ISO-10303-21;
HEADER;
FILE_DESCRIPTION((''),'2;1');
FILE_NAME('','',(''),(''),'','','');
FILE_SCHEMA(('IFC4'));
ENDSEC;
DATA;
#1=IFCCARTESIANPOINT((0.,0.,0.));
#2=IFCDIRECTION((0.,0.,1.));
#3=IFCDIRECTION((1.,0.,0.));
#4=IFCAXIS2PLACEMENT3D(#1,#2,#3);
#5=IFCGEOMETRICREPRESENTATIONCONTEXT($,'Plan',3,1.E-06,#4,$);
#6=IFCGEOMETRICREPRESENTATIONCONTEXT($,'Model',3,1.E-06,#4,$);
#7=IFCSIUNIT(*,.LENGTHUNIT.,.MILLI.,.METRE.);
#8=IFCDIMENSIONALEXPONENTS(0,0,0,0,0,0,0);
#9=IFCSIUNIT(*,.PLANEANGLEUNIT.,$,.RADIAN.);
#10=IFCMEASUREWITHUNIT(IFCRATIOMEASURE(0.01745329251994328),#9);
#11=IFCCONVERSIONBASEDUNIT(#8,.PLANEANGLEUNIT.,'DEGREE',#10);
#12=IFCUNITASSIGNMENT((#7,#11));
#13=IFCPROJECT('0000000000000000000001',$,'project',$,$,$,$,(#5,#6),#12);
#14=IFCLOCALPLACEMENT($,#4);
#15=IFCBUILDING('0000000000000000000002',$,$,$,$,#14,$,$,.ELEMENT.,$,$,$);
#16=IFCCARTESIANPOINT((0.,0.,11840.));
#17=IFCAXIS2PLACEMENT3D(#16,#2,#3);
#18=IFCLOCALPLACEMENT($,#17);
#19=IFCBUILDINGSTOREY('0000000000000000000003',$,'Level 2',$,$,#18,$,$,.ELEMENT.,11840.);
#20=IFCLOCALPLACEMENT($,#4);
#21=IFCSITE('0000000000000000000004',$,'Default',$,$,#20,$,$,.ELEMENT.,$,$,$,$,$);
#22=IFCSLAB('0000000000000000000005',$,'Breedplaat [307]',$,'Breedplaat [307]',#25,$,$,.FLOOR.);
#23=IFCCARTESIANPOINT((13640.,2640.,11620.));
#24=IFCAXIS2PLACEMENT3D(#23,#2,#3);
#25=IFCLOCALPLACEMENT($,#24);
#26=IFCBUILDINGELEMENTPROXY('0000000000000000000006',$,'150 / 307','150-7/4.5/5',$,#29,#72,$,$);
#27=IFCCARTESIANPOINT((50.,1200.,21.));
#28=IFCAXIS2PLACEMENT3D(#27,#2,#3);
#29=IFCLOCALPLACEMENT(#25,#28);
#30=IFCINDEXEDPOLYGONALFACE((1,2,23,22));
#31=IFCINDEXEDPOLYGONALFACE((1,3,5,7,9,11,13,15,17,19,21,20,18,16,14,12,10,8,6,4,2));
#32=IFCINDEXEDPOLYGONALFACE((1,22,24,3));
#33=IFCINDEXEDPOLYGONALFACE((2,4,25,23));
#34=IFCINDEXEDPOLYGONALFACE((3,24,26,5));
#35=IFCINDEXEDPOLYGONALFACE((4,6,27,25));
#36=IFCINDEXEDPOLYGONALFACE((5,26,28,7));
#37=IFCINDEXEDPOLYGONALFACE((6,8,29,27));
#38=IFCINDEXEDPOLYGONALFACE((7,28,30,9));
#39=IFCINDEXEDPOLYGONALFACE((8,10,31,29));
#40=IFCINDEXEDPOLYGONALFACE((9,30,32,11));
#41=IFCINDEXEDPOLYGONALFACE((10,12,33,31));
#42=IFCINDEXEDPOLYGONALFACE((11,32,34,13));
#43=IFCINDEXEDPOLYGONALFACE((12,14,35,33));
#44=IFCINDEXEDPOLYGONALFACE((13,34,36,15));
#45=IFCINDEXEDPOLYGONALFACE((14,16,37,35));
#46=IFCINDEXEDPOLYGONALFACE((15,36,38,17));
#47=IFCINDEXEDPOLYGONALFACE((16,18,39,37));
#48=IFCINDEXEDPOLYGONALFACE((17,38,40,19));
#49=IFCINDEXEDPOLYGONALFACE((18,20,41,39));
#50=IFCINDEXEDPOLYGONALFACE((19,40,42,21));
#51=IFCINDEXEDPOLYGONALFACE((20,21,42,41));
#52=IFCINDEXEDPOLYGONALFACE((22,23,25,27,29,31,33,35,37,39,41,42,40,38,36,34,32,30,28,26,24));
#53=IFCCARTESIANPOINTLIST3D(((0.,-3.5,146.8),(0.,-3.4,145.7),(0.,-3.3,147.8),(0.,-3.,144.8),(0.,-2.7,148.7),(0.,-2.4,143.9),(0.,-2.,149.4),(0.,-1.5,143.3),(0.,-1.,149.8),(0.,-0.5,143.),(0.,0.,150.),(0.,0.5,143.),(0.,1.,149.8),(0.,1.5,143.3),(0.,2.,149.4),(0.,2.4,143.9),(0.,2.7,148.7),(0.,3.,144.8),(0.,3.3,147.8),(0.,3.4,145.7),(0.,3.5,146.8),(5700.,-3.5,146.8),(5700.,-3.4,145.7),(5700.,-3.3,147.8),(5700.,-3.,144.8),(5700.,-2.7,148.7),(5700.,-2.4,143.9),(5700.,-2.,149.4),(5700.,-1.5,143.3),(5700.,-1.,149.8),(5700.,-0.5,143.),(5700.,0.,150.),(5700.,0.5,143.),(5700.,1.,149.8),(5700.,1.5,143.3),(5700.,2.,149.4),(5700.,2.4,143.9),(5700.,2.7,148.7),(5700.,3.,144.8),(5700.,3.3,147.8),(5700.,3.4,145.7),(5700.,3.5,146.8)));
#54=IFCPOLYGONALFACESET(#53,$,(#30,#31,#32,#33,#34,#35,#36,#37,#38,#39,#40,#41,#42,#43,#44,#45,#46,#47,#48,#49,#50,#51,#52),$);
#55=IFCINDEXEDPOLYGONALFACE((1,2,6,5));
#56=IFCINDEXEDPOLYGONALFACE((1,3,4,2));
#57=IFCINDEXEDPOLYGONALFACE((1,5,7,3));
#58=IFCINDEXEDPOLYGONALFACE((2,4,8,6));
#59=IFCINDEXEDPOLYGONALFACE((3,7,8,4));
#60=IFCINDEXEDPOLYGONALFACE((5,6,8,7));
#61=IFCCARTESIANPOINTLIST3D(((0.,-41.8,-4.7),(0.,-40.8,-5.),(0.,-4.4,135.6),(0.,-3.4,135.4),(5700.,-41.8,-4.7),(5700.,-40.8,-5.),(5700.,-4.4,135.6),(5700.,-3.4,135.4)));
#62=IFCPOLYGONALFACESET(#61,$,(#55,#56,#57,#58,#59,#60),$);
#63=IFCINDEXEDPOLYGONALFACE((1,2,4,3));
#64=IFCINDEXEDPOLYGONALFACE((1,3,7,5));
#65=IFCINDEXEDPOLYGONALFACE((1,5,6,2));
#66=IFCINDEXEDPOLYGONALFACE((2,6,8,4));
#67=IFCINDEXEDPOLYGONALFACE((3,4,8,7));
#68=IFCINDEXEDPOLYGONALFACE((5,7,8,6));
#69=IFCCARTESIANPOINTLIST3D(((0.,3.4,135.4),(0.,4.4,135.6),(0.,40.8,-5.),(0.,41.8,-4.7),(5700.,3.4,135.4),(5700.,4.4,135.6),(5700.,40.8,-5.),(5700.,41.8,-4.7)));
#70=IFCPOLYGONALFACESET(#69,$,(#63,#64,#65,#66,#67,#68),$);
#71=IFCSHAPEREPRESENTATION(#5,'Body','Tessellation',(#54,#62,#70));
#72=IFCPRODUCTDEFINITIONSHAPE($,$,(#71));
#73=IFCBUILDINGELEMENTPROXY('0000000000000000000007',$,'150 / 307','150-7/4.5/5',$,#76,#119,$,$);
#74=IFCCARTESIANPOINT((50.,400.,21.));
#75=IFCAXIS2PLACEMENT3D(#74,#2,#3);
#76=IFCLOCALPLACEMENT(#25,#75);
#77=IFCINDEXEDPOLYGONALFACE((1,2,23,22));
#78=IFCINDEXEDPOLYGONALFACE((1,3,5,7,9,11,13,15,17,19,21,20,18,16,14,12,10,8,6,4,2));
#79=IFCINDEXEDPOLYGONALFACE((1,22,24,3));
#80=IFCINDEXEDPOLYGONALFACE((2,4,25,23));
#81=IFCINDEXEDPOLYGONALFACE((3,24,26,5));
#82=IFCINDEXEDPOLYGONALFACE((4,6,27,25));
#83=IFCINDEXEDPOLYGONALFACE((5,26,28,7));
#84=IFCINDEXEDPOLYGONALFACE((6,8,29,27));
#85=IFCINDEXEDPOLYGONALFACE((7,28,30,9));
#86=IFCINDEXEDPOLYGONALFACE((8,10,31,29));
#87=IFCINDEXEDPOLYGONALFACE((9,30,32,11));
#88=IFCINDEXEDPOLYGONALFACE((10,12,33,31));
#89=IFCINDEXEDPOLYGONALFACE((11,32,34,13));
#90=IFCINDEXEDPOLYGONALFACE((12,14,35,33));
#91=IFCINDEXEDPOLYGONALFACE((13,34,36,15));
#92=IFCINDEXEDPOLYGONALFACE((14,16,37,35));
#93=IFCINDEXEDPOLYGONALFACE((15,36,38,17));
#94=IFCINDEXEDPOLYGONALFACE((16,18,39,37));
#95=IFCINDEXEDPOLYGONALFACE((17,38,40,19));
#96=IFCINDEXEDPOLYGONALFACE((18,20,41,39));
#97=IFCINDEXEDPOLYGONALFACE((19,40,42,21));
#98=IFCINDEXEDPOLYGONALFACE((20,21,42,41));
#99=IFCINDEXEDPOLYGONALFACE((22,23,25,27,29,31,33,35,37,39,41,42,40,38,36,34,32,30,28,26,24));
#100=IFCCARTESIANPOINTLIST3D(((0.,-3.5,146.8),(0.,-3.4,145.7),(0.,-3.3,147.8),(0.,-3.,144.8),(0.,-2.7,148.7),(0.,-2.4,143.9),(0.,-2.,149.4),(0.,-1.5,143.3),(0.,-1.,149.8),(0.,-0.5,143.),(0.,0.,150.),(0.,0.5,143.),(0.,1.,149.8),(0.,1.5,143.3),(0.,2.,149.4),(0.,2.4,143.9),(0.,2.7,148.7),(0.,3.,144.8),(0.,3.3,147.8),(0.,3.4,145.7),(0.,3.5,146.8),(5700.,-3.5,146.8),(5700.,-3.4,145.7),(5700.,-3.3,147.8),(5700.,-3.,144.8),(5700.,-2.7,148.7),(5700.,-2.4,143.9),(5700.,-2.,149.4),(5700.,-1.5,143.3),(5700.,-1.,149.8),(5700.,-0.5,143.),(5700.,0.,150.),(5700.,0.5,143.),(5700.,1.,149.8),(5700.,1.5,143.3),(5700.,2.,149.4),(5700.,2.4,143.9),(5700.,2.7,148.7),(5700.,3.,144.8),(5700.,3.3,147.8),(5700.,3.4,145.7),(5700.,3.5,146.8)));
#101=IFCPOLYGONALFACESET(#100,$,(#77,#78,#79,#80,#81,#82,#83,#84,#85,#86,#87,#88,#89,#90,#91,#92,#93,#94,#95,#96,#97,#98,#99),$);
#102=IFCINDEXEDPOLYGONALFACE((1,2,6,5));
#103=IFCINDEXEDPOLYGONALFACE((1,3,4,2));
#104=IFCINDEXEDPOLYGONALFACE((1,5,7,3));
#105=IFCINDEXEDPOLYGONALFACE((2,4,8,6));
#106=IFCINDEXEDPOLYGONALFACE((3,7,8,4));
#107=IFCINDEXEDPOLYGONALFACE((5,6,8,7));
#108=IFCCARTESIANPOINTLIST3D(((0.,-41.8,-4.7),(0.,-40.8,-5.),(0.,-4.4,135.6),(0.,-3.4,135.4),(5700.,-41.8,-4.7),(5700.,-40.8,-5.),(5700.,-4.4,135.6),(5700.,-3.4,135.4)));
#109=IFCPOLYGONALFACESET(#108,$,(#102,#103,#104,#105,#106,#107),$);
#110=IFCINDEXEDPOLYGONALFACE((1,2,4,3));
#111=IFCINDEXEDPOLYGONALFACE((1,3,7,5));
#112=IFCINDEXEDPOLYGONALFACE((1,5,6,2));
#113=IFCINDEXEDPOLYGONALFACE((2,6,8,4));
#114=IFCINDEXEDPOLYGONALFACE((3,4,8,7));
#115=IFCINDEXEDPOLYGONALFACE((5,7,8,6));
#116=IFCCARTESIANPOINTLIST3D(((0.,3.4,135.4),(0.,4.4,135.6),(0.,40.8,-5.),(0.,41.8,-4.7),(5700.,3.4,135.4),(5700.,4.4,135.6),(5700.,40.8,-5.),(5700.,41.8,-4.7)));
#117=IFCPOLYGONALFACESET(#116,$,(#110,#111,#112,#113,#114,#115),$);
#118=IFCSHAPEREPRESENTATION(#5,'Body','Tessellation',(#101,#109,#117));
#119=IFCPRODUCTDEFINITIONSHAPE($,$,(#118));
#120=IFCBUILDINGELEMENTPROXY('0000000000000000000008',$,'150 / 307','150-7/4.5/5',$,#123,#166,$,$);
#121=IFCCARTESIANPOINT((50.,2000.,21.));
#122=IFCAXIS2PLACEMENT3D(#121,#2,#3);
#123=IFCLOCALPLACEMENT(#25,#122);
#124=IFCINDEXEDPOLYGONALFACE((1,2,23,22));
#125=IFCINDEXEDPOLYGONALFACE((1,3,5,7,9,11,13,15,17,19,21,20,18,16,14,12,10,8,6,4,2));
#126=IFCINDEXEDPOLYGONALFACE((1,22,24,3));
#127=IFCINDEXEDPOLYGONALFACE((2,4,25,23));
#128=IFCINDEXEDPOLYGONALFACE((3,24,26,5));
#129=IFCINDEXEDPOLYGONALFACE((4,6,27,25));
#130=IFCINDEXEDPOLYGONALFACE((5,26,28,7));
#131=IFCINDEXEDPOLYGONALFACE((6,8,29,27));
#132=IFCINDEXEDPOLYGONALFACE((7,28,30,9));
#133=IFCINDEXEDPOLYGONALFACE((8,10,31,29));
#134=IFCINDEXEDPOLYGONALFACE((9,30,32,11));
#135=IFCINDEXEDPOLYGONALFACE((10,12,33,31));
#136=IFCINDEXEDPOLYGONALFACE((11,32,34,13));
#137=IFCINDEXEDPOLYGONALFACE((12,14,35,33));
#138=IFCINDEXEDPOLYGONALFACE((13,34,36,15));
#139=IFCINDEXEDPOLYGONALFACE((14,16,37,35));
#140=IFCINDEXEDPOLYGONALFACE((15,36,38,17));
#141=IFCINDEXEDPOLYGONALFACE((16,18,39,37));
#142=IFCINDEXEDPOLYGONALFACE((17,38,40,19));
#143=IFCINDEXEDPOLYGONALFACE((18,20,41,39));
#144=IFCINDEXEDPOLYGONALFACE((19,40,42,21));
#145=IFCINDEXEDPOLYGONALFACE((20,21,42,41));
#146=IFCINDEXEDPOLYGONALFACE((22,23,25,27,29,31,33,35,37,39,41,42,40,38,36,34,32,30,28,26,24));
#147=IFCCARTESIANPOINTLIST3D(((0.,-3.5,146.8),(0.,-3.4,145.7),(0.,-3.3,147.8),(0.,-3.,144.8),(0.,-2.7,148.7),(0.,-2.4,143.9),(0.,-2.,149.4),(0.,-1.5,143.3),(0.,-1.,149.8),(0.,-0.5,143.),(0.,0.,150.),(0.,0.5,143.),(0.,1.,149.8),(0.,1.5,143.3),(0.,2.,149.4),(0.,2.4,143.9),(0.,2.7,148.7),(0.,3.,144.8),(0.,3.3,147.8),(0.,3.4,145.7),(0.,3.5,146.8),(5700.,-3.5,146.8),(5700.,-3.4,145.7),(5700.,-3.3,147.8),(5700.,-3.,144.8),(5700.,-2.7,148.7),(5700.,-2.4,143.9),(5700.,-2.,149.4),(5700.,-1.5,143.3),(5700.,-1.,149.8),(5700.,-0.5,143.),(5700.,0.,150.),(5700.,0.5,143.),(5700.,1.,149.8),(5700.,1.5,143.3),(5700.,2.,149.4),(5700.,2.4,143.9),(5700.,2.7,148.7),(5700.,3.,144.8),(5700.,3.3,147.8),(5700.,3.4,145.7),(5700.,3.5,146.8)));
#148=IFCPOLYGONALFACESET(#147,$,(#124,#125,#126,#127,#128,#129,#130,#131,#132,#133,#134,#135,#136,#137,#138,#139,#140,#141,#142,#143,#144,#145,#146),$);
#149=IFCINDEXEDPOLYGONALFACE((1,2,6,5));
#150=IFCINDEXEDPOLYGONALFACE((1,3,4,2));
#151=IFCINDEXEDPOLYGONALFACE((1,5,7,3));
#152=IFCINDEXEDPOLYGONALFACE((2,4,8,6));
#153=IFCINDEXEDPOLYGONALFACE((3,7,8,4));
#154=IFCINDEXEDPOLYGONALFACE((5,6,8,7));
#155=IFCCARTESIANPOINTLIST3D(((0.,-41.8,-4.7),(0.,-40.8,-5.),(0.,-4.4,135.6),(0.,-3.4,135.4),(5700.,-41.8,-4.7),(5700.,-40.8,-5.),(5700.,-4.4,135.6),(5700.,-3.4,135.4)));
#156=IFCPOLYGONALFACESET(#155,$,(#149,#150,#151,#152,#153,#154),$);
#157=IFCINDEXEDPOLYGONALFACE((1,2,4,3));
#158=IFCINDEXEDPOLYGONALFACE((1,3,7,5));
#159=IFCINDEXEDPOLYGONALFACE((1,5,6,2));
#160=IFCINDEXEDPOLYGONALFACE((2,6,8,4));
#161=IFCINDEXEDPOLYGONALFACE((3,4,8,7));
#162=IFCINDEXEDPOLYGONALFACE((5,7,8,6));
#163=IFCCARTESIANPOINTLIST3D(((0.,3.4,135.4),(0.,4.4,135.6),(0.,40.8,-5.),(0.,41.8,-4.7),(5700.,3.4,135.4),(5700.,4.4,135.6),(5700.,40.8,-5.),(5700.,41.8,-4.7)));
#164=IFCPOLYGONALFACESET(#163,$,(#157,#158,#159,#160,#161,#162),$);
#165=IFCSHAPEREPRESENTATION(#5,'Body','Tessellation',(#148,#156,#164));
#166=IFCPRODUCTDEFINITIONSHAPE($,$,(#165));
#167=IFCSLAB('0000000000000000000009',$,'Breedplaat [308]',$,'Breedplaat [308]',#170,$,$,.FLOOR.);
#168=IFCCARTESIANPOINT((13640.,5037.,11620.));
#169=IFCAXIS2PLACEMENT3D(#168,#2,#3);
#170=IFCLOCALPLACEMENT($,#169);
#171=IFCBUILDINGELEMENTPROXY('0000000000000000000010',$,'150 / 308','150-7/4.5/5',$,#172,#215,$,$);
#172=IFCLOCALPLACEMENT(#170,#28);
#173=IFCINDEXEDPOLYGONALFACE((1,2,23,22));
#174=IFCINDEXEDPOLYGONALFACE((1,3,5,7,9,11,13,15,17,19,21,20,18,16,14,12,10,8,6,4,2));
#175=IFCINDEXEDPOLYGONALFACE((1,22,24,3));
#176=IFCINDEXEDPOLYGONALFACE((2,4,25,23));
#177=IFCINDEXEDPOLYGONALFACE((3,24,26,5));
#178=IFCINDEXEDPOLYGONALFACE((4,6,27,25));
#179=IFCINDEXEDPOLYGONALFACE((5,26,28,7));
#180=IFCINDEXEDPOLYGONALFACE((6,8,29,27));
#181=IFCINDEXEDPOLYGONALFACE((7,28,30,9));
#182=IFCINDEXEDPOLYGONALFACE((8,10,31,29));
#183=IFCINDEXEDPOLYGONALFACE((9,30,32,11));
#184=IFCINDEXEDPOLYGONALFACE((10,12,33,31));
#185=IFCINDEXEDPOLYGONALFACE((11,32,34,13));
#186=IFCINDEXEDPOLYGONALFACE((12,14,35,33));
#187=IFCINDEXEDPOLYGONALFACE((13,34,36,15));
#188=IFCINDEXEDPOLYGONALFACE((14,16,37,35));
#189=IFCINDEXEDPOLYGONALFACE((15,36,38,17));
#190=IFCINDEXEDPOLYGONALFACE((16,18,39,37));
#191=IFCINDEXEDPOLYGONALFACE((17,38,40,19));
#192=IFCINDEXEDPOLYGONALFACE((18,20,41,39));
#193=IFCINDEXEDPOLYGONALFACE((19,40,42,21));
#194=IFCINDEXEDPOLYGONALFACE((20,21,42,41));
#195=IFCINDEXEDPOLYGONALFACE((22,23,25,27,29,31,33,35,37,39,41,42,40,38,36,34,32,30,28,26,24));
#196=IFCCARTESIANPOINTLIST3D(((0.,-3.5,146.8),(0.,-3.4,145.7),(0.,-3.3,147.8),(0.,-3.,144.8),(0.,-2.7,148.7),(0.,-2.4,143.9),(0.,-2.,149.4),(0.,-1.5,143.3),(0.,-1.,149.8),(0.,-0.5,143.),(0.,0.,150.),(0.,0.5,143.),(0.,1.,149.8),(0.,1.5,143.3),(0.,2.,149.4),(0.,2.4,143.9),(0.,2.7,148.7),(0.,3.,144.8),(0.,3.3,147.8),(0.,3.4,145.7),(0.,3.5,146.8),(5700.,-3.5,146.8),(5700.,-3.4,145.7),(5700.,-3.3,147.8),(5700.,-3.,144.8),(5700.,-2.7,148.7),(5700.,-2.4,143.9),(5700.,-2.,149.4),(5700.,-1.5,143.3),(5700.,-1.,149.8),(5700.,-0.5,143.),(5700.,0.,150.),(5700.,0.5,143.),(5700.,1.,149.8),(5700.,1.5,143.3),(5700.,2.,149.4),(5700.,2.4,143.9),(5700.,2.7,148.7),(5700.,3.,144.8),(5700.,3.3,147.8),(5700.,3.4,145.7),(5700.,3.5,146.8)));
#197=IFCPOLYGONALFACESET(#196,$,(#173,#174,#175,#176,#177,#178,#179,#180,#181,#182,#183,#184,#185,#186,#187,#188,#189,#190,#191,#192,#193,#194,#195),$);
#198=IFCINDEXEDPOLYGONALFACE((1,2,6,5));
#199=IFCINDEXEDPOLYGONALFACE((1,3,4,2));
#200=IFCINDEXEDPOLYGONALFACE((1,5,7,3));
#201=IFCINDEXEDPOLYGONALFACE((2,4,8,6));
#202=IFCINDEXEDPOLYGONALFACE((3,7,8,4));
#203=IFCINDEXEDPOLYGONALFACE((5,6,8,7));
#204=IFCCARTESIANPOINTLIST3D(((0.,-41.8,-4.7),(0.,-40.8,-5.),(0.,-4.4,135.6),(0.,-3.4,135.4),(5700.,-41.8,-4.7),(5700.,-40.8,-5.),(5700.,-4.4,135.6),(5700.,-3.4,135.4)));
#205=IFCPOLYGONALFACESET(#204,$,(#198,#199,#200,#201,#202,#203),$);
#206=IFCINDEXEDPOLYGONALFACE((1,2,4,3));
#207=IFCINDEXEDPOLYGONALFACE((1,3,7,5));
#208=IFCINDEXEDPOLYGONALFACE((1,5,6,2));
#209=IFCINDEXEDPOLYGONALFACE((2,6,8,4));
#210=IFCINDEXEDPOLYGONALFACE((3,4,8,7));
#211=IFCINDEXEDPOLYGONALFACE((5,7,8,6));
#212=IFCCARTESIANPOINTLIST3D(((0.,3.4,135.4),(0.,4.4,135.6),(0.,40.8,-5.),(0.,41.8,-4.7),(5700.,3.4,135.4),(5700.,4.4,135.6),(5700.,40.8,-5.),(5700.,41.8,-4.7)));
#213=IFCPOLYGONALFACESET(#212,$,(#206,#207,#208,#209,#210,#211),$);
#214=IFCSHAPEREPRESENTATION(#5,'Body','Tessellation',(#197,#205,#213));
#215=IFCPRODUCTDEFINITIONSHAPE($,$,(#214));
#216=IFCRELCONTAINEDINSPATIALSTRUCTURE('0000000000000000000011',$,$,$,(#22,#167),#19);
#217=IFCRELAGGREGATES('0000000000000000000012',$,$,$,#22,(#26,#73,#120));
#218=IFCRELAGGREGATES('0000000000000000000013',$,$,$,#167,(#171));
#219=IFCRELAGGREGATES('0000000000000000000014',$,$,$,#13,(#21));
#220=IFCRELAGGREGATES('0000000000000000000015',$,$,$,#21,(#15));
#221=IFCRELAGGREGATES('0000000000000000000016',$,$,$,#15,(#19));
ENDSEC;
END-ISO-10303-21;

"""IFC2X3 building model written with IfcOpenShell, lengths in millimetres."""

from ifc_helpers import new_model, entity, si_unit, converted_unit, frame, origin_with_axes, origin_2d_with_axis, place, context, project, spatial, rectangle, circle, extrude, element, aggregate, save


model = new_model("IFC2X3")

# Units and contexts
plan_context = context("Plan", 3, precision=1e-06, world=origin_with_axes())
model_context = context("Model", 3, precision=1e-06, world=origin_with_axes())
ifc_project = project(units=[si_unit("LENGTHUNIT", "METRE", prefix="MILLI"), converted_unit("PLANEANGLEUNIT", "DEGREE", entity("IfcRatioMeasure", 0.01745329251994328), si_unit("PLANEANGLEUNIT", "RADIAN"), dimensions=[0, 0, 0, 0, 0, 0, 0])], contexts=[plan_context, model_context])

# Site, building, storey
site_placement = place(None, origin_with_axes())
site = spatial("IfcSite", under=ifc_project, at=site_placement, Name="Default", CompositionType="ELEMENT")
building_placement = place(None, origin_with_axes())
building = spatial("IfcBuilding", under=site, at=building_placement, CompositionType="ELEMENT")
storey_placement = place(None, frame((0.0, 0.0, 11840.0), z_axis=(0.0, 0.0, 1.0), x_axis=(1.0, 0.0, 0.0)))
storey = spatial("IfcBuildingStorey", under=building, at=storey_placement, Name="Level 2", CompositionType="ELEMENT", Elevation=11840.0)

# Slabs, building element proxies
slab_1_placement = place(None, frame((13640.0, 2640.0, 11620.0), z_axis=(0.0, 0.0, 1.0), x_axis=(1.0, 0.0, 0.0)))
slab_1 = element("IfcSlab", 1, at=slab_1_placement, inside=storey, Name="Breedplaat [307]", ObjectType="Breedplaat [307]", PredefinedType="FLOOR")
proxy_1_placement = place(slab_1_placement, frame((50.0, 1200.0, 21.0), z_axis=(0.0, 0.0, 1.0), x_axis=(1.0, 0.0, 0.0)))
proxy_1 = element("IfcBuildingElementProxy", 2, at=proxy_1_placement, Name="150 / 307", Description="150-7/4.5/5", context=plan_context, shape_type="SweptSolid", body=[
    extrude(circle(Radius=3.5, at=origin_2d_with_axis()), frame((0.0, 0.0, 146.5), z_axis=(1.0, 0.0, 0.0), x_axis=(0.0, 0.0, 1.0)), (0.0, 0.0, 1.0), 5700.0),
    extrude(rectangle(XDim=145.2, YDim=1.0, at=origin_2d_with_axis()), frame((0.0, -22.6, 65.3), z_axis=(1.0, 0.0, 0.0), x_axis=(0.0, 0.257663, 0.966235)), (0.0, 0.0, 1.0), 5700.0),
    extrude(rectangle(XDim=145.2, YDim=1.0, at=origin_2d_with_axis()), frame((0.0, 22.6, 65.3), z_axis=(1.0, 0.0, 0.0), x_axis=(0.0, -0.257663, 0.966235)), (0.0, 0.0, 1.0), 5700.0),
])
proxy_2_placement = place(slab_1_placement, frame((50.0, 400.0, 21.0), z_axis=(0.0, 0.0, 1.0), x_axis=(1.0, 0.0, 0.0)))
proxy_2 = element("IfcBuildingElementProxy", 3, at=proxy_2_placement, Name="150 / 307", Description="150-7/4.5/5", context=plan_context, shape_type="SweptSolid", body=[
    extrude(circle(Radius=3.5, at=origin_2d_with_axis()), frame((0.0, 0.0, 146.5), z_axis=(1.0, 0.0, 0.0), x_axis=(0.0, 0.0, 1.0)), (0.0, 0.0, 1.0), 5700.0),
    extrude(rectangle(XDim=145.2, YDim=1.0, at=origin_2d_with_axis()), frame((0.0, -22.6, 65.3), z_axis=(1.0, 0.0, 0.0), x_axis=(0.0, 0.257663, 0.966235)), (0.0, 0.0, 1.0), 5700.0),
    extrude(rectangle(XDim=145.2, YDim=1.0, at=origin_2d_with_axis()), frame((0.0, 22.6, 65.3), z_axis=(1.0, 0.0, 0.0), x_axis=(0.0, -0.257663, 0.966235)), (0.0, 0.0, 1.0), 5700.0),
])
proxy_3_placement = place(slab_1_placement, frame((50.0, 2000.0, 21.0), z_axis=(0.0, 0.0, 1.0), x_axis=(1.0, 0.0, 0.0)))
proxy_3 = element("IfcBuildingElementProxy", 4, at=proxy_3_placement, Name="150 / 307", Description="150-7/4.5/5", context=plan_context, shape_type="SweptSolid", body=[
    extrude(circle(Radius=3.5, at=origin_2d_with_axis()), frame((0.0, 0.0, 146.5), z_axis=(1.0, 0.0, 0.0), x_axis=(0.0, 0.0, 1.0)), (0.0, 0.0, 1.0), 5700.0),
    extrude(rectangle(XDim=145.2, YDim=1.0, at=origin_2d_with_axis()), frame((0.0, -22.6, 65.3), z_axis=(1.0, 0.0, 0.0), x_axis=(0.0, 0.257663, 0.966235)), (0.0, 0.0, 1.0), 5700.0),
    extrude(rectangle(XDim=145.2, YDim=1.0, at=origin_2d_with_axis()), frame((0.0, 22.6, 65.3), z_axis=(1.0, 0.0, 0.0), x_axis=(0.0, -0.257663, 0.966235)), (0.0, 0.0, 1.0), 5700.0),
])
aggregate(slab_1, [proxy_1, proxy_2, proxy_3])
slab_2_placement = place(None, frame((13640.0, 5037.0, 11620.0), z_axis=(0.0, 0.0, 1.0), x_axis=(1.0, 0.0, 0.0)))
slab_2 = element("IfcSlab", 5, at=slab_2_placement, inside=storey, Name="Breedplaat [308]", ObjectType="Breedplaat [308]", PredefinedType="FLOOR")
proxy_4_placement = place(slab_2_placement, frame((50.0, 1200.0, 21.0), z_axis=(0.0, 0.0, 1.0), x_axis=(1.0, 0.0, 0.0)))
proxy_4 = element("IfcBuildingElementProxy", 6, at=proxy_4_placement, Name="150 / 308", Description="150-7/4.5/5", context=plan_context, shape_type="SweptSolid", body=[
    extrude(circle(Radius=3.5, at=origin_2d_with_axis()), frame((0.0, 0.0, 146.5), z_axis=(1.0, 0.0, 0.0), x_axis=(0.0, 0.0, 1.0)), (0.0, 0.0, 1.0), 5700.0),
    extrude(rectangle(XDim=145.2, YDim=1.0, at=origin_2d_with_axis()), frame((0.0, -22.6, 65.3), z_axis=(1.0, 0.0, 0.0), x_axis=(0.0, 0.257663, 0.966235)), (0.0, 0.0, 1.0), 5700.0),
    extrude(rectangle(XDim=145.2, YDim=1.0, at=origin_2d_with_axis()), frame((0.0, 22.6, 65.3), z_axis=(1.0, 0.0, 0.0), x_axis=(0.0, -0.257663, 0.966235)), (0.0, 0.0, 1.0), 5700.0),
])
aggregate(slab_2, [proxy_4])

save(model, "model.ifc")
